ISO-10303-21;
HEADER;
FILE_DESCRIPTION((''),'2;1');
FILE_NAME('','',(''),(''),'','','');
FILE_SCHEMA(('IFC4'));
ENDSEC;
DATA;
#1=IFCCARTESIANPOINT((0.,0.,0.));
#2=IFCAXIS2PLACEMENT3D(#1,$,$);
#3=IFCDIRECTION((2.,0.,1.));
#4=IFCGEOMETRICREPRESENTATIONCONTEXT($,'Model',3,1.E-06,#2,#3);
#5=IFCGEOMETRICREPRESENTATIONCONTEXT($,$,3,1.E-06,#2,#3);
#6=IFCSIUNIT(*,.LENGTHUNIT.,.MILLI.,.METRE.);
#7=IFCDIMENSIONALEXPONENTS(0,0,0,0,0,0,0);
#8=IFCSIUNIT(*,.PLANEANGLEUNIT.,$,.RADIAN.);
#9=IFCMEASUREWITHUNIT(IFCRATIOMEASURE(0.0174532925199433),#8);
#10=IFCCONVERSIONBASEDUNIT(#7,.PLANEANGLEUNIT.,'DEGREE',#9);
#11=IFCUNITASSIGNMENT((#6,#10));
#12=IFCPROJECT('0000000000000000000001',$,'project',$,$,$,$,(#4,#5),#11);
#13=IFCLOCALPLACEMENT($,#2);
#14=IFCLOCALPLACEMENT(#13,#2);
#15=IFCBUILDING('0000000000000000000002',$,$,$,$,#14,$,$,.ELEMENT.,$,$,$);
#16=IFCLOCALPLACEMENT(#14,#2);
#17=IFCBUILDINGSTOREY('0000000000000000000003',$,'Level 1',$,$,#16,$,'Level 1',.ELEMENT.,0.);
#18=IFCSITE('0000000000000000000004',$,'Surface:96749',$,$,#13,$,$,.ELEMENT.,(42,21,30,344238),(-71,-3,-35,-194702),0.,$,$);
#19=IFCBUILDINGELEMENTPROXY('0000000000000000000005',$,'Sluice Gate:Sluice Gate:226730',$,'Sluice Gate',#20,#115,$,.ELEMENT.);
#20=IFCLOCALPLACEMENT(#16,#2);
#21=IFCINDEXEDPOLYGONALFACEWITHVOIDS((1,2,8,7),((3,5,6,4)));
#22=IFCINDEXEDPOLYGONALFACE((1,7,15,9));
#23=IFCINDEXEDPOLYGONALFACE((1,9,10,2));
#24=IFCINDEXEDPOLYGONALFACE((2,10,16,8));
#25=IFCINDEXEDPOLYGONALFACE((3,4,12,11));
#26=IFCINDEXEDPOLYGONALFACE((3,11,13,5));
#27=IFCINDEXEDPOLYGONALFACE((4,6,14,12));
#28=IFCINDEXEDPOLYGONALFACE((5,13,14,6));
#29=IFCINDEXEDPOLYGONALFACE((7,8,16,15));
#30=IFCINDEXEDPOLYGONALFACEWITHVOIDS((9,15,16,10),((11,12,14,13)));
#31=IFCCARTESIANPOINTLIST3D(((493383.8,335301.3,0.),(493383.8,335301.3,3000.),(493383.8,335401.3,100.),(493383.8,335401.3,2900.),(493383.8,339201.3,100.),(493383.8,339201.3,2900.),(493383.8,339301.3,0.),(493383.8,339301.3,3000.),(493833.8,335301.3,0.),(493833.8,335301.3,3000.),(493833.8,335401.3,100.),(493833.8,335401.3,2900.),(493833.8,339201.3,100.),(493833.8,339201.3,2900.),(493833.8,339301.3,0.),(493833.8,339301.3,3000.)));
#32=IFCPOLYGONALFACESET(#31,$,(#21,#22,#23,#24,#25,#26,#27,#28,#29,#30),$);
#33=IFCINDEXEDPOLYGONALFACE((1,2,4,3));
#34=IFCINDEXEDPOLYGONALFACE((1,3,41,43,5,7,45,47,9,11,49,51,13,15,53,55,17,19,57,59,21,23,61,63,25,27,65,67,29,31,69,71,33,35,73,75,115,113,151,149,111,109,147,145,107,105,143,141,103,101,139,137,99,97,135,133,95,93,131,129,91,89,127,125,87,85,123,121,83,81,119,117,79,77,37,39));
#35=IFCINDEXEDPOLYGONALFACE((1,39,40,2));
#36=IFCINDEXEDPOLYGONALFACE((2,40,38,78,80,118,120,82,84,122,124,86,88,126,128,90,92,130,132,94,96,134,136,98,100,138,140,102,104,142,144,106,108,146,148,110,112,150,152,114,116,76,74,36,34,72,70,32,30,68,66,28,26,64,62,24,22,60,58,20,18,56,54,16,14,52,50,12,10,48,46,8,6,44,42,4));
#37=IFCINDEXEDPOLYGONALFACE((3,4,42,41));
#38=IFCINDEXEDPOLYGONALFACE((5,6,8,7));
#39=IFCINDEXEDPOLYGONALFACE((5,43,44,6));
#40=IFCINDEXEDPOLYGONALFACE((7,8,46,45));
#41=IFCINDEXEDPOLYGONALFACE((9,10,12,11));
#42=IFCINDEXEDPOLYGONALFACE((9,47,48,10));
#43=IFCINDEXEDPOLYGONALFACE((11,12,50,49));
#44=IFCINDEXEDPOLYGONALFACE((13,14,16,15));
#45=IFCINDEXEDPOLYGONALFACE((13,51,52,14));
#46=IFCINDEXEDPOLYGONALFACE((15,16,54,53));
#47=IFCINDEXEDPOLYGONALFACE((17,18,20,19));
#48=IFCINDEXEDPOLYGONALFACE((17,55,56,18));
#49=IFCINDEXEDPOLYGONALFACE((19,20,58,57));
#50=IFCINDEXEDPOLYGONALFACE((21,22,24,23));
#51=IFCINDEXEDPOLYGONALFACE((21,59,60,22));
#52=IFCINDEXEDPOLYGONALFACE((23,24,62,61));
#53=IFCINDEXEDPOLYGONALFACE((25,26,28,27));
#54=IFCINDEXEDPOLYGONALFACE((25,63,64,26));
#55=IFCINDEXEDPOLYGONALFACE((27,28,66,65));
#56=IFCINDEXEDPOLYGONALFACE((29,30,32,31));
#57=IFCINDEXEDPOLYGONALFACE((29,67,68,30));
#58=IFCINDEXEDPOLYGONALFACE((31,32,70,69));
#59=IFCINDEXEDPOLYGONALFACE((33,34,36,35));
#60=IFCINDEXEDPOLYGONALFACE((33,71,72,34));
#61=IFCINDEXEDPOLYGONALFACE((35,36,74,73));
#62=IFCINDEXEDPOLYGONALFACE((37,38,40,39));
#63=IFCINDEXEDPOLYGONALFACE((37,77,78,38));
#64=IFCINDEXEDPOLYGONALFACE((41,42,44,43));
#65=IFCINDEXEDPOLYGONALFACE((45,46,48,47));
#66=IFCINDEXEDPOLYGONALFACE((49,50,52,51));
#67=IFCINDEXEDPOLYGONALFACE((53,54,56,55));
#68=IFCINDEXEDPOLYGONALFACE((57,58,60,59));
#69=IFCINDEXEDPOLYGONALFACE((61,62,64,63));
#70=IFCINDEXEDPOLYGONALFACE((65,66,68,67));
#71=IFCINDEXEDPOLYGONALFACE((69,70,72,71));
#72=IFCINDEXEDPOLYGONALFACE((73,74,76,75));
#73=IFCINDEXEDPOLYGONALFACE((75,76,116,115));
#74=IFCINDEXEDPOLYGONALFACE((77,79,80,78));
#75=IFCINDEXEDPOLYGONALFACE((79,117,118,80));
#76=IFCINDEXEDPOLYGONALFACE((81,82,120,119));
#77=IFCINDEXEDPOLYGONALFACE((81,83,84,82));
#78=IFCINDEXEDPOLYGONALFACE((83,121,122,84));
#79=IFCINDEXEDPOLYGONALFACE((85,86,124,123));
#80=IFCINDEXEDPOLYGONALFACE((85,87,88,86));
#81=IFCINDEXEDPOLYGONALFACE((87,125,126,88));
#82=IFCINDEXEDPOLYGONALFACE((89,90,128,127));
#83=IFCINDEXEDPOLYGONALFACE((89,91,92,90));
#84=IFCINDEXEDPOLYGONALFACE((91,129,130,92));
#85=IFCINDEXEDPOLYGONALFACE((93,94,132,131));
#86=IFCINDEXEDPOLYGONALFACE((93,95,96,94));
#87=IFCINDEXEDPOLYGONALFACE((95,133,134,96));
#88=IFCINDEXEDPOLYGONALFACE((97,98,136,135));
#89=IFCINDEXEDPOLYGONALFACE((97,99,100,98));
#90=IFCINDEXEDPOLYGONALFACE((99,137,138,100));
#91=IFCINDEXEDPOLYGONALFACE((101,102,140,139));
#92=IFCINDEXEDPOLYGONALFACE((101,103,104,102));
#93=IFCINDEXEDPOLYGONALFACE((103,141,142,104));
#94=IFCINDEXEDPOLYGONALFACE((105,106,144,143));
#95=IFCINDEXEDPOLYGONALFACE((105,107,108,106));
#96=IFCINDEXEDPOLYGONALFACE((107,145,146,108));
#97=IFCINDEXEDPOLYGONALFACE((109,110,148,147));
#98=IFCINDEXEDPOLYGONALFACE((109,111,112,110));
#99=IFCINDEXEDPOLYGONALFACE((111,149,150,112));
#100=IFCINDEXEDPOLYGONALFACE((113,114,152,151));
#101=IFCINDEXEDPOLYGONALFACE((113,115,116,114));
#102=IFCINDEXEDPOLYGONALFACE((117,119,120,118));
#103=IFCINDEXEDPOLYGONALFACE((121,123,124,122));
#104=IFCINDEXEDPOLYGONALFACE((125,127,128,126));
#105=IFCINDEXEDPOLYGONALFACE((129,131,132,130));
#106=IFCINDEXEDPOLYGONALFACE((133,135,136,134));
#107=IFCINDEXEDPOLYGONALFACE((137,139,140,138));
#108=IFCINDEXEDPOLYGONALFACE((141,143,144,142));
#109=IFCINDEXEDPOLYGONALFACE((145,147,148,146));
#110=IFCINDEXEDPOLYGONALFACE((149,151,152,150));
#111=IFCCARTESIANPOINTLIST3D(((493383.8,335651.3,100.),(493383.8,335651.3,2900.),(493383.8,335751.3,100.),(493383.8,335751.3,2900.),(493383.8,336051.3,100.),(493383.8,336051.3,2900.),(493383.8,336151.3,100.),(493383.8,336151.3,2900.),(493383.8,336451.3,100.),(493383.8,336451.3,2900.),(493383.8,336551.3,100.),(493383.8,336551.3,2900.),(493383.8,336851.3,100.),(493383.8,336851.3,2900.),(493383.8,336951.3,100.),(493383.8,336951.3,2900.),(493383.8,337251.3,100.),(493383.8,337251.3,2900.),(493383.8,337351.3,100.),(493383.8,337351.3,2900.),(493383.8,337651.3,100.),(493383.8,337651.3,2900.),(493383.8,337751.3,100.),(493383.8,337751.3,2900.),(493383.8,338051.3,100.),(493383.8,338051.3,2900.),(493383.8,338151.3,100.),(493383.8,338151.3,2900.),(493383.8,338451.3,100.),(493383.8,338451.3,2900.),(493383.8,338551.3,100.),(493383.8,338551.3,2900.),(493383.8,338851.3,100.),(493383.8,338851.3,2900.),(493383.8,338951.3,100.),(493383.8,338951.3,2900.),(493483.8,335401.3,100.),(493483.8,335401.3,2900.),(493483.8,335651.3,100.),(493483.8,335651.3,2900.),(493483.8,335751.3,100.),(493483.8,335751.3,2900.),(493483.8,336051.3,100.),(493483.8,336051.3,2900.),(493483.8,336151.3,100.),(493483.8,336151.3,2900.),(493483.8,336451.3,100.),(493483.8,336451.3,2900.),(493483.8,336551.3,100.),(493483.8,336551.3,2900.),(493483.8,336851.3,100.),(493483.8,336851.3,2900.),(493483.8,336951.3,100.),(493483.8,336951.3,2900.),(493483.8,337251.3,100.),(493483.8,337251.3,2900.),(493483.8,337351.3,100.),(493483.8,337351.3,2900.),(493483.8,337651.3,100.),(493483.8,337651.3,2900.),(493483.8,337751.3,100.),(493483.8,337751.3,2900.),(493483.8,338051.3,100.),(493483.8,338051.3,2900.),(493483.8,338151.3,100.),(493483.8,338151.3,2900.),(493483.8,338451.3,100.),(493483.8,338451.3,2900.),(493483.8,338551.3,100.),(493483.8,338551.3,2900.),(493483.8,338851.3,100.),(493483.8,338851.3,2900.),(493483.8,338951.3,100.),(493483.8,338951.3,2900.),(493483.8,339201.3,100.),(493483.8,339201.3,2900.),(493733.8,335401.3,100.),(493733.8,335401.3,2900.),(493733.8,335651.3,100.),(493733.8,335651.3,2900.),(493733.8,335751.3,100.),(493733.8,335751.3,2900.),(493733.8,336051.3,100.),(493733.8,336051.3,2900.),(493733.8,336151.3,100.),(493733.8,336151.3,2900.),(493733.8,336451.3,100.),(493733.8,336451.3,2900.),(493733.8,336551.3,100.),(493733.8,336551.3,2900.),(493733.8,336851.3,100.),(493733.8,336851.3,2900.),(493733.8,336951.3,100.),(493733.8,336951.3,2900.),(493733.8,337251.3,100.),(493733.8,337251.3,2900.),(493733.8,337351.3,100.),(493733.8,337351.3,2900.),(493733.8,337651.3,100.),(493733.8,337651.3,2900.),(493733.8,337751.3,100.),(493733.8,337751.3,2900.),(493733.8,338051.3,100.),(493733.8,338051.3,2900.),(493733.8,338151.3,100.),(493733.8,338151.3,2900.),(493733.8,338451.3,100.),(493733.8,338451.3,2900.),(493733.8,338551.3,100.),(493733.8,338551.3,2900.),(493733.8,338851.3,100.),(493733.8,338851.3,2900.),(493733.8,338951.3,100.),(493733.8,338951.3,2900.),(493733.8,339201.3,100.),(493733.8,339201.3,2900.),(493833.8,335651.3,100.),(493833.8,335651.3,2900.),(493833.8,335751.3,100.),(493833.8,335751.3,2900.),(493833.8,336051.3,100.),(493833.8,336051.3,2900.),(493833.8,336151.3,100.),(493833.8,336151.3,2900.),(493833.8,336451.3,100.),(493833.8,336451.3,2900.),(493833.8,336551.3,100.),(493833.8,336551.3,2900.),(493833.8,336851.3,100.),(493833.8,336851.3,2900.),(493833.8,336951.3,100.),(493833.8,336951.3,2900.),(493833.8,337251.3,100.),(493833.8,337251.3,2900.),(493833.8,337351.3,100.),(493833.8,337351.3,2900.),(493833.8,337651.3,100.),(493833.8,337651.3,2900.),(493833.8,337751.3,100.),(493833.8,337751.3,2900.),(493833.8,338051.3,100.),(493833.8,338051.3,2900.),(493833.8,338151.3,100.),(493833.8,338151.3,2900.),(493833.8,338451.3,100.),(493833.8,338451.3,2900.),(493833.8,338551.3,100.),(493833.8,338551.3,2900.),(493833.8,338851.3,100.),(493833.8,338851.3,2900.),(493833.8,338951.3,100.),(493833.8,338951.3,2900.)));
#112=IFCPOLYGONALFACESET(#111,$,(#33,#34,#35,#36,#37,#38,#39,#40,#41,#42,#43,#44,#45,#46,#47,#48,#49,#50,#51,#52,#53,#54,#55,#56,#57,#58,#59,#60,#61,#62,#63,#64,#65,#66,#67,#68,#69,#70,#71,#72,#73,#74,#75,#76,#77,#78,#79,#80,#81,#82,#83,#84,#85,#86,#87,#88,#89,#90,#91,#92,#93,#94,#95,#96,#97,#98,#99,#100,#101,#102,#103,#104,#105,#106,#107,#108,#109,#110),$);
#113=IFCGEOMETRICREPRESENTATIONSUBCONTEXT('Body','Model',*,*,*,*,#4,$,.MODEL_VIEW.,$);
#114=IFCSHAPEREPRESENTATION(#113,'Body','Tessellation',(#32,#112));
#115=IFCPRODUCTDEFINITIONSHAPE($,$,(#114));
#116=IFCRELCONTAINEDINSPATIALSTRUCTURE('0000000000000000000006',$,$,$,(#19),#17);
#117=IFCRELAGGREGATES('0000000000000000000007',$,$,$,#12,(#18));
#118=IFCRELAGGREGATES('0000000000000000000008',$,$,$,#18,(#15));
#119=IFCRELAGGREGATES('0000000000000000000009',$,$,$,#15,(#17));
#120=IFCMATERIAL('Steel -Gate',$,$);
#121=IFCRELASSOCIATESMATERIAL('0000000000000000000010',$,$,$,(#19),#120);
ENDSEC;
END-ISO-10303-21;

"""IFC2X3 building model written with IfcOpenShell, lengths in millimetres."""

from ifc_helpers import new_model, entity, si_unit, converted_unit, direction, frame, origin, place, context, subcontext, project, spatial, polyline, outline, extrude, source, transform, mapped, material, element, save


model = new_model("IFC2X3")

# Units and contexts
model_context = context("Model", 3, precision=1e-06, world=origin(), true_north=direction((2.0, 0.0, 1.0)))
context_of_model = context(None, 3, precision=1e-06, world=origin(), true_north=direction((2.0, 0.0, 1.0)))
body_context = subcontext(model_context, "Body", "Model", "MODEL_VIEW")
ifc_project = project(units=[si_unit("LENGTHUNIT", "METRE", prefix="MILLI"), converted_unit("PLANEANGLEUNIT", "DEGREE", entity("IfcRatioMeasure", 0.0174532925199433), si_unit("PLANEANGLEUNIT", "RADIAN"), dimensions=[0, 0, 0, 0, 0, 0, 0])], contexts=[model_context, context_of_model])

# Site, building, storey
site_placement = place(None, origin())
site = spatial("IfcSite", under=ifc_project, at=site_placement, Name="Surface:96749", CompositionType="ELEMENT", RefLatitude=(42, 21, 30, 344238), RefLongitude=(-71, -3, -35, -194702), RefElevation=0.0)
building_placement = place(site_placement, origin())
building = spatial("IfcBuilding", under=site, at=building_placement, CompositionType="ELEMENT")
storey_placement = place(building_placement, origin())
storey = spatial("IfcBuildingStorey", under=building, at=storey_placement, Name="Level 1", LongName="Level 1", CompositionType="ELEMENT", Elevation=0.0)

# Building element proxy
ifc_material = material(Name="Steel -Gate")
shared_shape_1 = source(origin(), body_context, "Body", "SweptSolid", [
    extrude(outline(polyline([(-2000.0, -1500.0), (2000.0, -1500.0), (2000.0, 1500.0), (-2000.0, 1500.0), (-2000.0, -1500.0)]), holes=[polyline([(-1900.0, 1400.0), (1900.0, 1400.0), (1900.0, -1400.0), (-1900.0, -1400.0), (-1900.0, 1400.0)])]), frame((0.0, -225.0, 1500.0), z_axis=(0.0, 1.0, 0.0), x_axis=(-1.0, 0.0, 0.0)), (0.0, 0.0, 1.0), 450.0),
    extrude(outline(polyline([(125.0, -1650.0), (225.0, -1650.0), (225.0, -1550.0), (125.0, -1550.0), (125.0, -1250.0), (225.0, -1250.0), (225.0, -1150.0), (125.0, -1150.0), (125.0, -850.0), (225.0, -850.0), (225.0, -750.0), (125.0, -750.0), (125.0, -450.0), (225.0, -450.0), (225.0, -350.0), (125.0, -350.0), (125.0, -50.0), (225.0, -50.0), (225.0, 50.0), (125.0, 50.0), (125.0, 350.0), (225.0, 350.0), (225.0, 450.0), (125.0, 450.0), (125.0, 750.0), (225.0, 750.0), (225.0, 850.0), (125.0, 850.0), (125.0, 1150.0), (225.0, 1150.0), (225.0, 1250.0), (125.0, 1250.0), (125.0, 1550.0), (225.0, 1550.0), (225.0, 1650.0), (125.0, 1650.0), (125.0, 1900.0), (-125.0, 1900.0), (-125.0, 1650.0), (-225.0, 1650.0), (-225.0, 1550.0), (-125.0, 1550.0), (-125.0, 1250.0), (-225.0, 1250.0), (-225.0, 1150.0), (-125.0, 1150.0), (-125.0, 850.0), (-225.0, 850.0), (-225.0, 750.0), (-125.0, 750.0), (-125.0, 450.0), (-225.0, 450.0), (-225.0, 350.0), (-125.0, 350.0), (-125.0, 50.0), (-225.0, 50.0), (-225.0, -50.0), (-125.0, -50.0), (-125.0, -350.0), (-225.0, -350.0), (-225.0, -450.0), (-125.0, -450.0), (-125.0, -750.0), (-225.0, -750.0), (-225.0, -850.0), (-125.0, -850.0), (-125.0, -1150.0), (-225.0, -1150.0), (-225.0, -1250.0), (-125.0, -1250.0), (-125.0, -1550.0), (-225.0, -1550.0), (-225.0, -1650.0), (-125.0, -1650.0), (-125.0, -1900.0), (125.0, -1900.0), (125.0, -1650.0)])), frame((0.0, 0.0, 100.0), z_axis=(0.0, 0.0, 1.0), x_axis=(0.0, -1.0, 0.0)), (0.0, 0.0, 1.0), 2800.0),
])
for number, where, z_axis, x_axis, name in (
    (1, (493608.8, 337301.3, 0.0), (0.0, 0.0, 1.0), (0.0, 1.0, 0.0), "Sluice Gate:Sluice Gate:226730"),
):
    element("IfcBuildingElementProxy", number, at=place(storey_placement, frame(where, z_axis=z_axis, x_axis=x_axis)), inside=storey, material=ifc_material, Name=name, ObjectType="Sluice Gate", CompositionType="ELEMENT", context=body_context, shape_type="MappedRepresentation", body=[
        mapped(shared_shape_1, transform((0.0, 0.0, 0.0), scale=1.0)),
    ])

save(model, "model.ifc")
